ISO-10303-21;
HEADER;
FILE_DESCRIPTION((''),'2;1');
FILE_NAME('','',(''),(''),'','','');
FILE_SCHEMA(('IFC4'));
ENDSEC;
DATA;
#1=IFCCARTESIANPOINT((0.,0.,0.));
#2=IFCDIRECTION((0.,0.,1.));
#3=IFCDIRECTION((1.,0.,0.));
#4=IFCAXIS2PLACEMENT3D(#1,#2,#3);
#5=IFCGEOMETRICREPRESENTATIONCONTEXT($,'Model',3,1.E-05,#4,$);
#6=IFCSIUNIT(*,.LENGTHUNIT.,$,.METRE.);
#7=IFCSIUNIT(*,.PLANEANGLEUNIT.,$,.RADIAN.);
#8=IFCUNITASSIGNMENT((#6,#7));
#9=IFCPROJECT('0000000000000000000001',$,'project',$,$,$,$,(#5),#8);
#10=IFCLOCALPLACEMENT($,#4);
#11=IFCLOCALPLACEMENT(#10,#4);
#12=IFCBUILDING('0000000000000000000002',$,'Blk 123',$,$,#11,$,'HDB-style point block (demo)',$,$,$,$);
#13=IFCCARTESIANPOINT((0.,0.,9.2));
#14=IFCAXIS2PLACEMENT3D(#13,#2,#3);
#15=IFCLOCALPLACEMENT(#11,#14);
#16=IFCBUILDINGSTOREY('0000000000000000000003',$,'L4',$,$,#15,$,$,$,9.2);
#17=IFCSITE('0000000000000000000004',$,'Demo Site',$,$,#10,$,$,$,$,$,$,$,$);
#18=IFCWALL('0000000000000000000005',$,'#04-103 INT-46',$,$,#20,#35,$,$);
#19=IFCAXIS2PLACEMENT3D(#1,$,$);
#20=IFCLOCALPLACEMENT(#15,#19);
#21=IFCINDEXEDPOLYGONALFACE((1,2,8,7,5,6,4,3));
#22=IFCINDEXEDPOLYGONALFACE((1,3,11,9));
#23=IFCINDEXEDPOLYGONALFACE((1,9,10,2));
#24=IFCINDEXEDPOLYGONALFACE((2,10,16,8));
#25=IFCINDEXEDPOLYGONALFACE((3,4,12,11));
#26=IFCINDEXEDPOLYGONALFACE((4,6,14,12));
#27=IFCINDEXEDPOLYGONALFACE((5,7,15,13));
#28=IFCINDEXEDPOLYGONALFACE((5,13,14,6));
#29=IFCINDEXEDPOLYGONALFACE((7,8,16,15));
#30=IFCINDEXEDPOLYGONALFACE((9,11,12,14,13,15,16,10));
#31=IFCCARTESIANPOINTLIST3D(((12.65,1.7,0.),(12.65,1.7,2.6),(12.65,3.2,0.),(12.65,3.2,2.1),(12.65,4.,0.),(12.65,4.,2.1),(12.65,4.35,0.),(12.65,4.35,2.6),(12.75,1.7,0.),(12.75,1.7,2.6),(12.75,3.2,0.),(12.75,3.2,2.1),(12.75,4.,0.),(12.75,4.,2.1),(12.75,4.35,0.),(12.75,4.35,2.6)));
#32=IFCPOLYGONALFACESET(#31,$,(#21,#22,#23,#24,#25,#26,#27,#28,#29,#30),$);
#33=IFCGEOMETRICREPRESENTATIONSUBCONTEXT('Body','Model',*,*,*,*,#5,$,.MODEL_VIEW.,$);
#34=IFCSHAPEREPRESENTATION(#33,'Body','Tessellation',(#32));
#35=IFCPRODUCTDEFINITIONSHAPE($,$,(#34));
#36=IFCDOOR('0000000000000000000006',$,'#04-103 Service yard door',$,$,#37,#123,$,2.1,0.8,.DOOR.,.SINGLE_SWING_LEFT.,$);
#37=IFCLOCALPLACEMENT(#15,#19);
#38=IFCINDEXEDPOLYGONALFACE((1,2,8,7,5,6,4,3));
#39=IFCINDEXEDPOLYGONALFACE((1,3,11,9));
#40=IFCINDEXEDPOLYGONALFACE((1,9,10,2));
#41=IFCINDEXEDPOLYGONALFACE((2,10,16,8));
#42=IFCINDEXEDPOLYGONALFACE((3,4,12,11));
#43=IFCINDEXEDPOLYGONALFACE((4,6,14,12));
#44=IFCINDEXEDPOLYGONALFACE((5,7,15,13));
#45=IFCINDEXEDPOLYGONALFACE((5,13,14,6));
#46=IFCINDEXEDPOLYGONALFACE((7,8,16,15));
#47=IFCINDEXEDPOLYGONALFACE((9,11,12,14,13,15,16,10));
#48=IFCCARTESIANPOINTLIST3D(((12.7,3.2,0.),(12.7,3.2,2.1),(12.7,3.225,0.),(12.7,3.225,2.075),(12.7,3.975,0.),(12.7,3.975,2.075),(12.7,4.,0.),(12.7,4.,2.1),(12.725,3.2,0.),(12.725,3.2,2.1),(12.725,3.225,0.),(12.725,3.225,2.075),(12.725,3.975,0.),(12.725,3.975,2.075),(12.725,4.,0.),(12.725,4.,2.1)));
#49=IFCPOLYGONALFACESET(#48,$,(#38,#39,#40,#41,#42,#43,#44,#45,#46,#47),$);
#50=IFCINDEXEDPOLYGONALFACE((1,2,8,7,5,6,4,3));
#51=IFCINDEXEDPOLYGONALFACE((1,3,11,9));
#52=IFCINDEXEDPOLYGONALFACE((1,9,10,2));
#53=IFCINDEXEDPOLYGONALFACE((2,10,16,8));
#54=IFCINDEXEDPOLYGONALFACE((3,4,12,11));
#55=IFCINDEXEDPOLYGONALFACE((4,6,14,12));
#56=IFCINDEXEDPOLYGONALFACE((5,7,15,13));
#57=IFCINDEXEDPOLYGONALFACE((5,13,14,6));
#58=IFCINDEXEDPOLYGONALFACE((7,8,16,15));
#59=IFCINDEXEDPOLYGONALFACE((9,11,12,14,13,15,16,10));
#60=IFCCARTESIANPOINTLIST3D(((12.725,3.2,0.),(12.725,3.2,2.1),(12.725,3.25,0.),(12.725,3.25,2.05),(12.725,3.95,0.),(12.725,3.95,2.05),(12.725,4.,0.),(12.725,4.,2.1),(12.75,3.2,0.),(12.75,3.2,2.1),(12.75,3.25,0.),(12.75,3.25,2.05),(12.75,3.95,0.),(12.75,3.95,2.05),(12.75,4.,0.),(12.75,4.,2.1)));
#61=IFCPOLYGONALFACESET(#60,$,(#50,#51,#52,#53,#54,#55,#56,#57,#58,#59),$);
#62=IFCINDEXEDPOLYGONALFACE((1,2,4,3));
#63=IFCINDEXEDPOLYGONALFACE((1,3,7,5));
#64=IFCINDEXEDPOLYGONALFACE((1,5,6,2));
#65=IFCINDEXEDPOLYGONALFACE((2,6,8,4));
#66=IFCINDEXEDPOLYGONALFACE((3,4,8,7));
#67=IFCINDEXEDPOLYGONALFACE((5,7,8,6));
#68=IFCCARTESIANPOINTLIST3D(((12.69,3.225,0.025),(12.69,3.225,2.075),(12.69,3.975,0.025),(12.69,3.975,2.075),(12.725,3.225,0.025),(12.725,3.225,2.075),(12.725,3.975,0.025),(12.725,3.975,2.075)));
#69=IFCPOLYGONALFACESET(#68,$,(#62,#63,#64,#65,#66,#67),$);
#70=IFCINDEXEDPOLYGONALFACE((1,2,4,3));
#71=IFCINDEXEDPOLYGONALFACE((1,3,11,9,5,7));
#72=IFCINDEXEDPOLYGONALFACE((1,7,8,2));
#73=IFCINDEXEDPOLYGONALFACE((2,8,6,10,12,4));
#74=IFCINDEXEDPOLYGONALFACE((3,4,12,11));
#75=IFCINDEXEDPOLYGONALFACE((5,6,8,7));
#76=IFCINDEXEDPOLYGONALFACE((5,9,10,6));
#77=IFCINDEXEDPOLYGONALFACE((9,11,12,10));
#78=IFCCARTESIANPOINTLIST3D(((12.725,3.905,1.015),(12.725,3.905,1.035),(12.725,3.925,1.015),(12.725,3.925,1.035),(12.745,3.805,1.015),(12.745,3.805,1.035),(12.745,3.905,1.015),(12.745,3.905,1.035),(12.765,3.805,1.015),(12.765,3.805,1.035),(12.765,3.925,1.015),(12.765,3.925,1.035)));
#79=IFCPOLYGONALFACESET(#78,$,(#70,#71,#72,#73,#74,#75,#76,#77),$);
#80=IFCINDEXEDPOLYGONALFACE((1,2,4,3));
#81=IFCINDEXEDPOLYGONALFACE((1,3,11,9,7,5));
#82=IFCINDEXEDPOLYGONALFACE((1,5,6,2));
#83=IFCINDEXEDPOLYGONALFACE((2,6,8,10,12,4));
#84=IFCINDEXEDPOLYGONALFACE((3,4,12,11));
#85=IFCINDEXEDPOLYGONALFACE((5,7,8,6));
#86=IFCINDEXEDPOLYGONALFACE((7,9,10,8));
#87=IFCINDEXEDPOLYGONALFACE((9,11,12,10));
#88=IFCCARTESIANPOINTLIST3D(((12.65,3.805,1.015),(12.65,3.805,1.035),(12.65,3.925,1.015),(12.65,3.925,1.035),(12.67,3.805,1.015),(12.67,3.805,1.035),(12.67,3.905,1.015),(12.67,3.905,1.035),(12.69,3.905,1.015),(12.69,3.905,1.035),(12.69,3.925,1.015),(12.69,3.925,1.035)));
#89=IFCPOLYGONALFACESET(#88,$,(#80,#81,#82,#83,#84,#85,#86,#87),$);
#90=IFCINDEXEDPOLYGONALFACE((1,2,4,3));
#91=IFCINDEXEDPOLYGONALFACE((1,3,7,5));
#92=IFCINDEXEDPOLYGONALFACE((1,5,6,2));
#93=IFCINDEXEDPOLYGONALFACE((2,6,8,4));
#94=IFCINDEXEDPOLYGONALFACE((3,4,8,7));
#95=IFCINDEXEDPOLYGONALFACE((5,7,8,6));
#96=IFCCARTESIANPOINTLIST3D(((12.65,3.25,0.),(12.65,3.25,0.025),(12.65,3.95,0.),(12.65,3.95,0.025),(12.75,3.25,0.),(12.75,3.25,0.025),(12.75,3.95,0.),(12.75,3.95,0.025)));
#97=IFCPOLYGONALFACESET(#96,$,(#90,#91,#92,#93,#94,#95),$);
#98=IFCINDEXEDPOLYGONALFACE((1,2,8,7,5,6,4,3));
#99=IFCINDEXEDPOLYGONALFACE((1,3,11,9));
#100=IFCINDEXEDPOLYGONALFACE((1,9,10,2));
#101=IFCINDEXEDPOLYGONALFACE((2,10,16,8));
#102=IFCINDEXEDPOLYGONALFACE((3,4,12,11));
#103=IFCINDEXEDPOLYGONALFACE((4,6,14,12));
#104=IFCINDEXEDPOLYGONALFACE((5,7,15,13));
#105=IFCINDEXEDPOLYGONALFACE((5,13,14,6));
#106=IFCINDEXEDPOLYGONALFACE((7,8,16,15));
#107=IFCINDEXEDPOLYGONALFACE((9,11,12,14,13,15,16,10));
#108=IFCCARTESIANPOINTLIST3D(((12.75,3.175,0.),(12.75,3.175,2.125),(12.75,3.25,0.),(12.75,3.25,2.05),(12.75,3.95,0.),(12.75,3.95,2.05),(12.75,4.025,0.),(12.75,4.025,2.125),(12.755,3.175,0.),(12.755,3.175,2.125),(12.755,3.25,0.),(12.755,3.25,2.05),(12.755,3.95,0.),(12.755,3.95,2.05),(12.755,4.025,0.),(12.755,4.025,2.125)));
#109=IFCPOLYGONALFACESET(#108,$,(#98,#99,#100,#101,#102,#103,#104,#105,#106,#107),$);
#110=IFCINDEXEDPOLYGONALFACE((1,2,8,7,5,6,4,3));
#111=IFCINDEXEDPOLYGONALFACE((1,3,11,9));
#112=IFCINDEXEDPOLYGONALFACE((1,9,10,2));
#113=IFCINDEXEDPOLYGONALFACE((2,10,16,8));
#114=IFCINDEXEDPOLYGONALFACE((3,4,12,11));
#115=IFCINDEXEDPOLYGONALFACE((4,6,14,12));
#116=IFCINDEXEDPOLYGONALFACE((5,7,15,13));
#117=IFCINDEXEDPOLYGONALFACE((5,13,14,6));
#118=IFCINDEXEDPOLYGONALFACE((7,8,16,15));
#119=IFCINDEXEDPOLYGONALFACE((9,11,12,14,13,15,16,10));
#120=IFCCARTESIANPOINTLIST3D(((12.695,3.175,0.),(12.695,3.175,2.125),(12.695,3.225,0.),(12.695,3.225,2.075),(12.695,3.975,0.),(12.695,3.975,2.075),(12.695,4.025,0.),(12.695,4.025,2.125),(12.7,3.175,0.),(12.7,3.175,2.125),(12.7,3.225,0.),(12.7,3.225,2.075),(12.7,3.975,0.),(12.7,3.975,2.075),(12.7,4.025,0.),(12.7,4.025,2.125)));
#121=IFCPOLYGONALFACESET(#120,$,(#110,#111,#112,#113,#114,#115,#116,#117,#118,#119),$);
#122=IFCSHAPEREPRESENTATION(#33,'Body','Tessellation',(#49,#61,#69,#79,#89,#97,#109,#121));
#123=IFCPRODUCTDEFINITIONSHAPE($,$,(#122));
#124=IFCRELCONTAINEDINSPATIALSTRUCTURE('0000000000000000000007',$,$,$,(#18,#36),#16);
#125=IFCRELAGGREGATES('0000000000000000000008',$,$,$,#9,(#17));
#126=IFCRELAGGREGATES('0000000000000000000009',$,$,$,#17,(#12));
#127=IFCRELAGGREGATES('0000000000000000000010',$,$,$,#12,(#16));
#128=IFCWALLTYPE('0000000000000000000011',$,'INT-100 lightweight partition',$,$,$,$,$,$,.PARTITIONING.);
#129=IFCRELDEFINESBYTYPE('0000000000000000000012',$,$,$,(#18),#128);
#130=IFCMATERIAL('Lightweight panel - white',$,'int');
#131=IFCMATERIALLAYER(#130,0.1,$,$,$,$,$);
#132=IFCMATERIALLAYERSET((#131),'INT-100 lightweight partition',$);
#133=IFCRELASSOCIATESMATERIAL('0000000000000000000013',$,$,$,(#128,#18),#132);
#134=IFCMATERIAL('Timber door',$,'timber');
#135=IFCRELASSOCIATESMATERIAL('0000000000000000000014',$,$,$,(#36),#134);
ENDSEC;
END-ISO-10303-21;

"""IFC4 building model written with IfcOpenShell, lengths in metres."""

from ifc_helpers import new_model, si_unit, frame, origin_with_axes, place, context, subcontext, project, spatial, line, indexed_curve, outline, extrude, material, layer, layer_set, layer_usage, type_object, element, fill, save


model = new_model("IFC4")

# Units and contexts
model_context = context("Model", 3, precision=1e-05, world=origin_with_axes())
body_context = subcontext(model_context, "Body", "Model", "MODEL_VIEW")
ifc_project = project(units=[si_unit("LENGTHUNIT", "METRE"), si_unit("PLANEANGLEUNIT", "RADIAN")], contexts=[model_context])

# Site, building, storey
site_placement = place(None, origin_with_axes())
site = spatial("IfcSite", under=ifc_project, at=site_placement, Name="Demo Site")
building_placement = place(site_placement, origin_with_axes())
building = spatial("IfcBuilding", under=site, at=building_placement, Name="Blk 123", LongName="HDB-style point block (demo)")
storey_placement = place(building_placement, frame((0.0, 0.0, 9.2), z_axis=(0.0, 0.0, 1.0), x_axis=(1.0, 0.0, 0.0)))
storey = spatial("IfcBuildingStorey", under=building, at=storey_placement, Name="L4", Elevation=9.2)

# Shared definitions
ifc_material_1 = material(Name="Timber door", Category="timber")

# Wall, opening, door
ifc_material_2 = material(Name="Lightweight panel - white", Category="int")
ifc_layer_1 = layer(ifc_material_2, 0.1)
ifc_layer_set_1 = layer_set([ifc_layer_1], Name="INT-100 lightweight partition")
ifc_layer_usage_1 = layer_usage(ifc_layer_set_1, "AXIS2", "POSITIVE", -0.05)
wall_type_1 = type_object("IfcWallType", Name="INT-100 lightweight partition", PredefinedType="PARTITIONING", material=ifc_layer_set_1)
wall_1_placement = place(storey_placement, frame((12.7, 1.7, 0.0), z_axis=(0.0, 0.0, 1.0), x_axis=(0.0, 1.0, 0.0)))
wall_1 = element("IfcWall", 1, at=wall_1_placement, inside=storey, type_object=wall_type_1, material=ifc_layer_usage_1, Name="#04-103 INT-46", context=body_context, shape_type="SweptSolid", body=[
    extrude(outline(indexed_curve([(0.0, 0.0), (0.0, 0.1), (2.65, 0.1), (2.65, 0.0), (0.0, 0.0)], self_intersect=False)), frame((0.0, -0.05, 0.0), z_axis=(0.0, 0.0, 1.0), x_axis=(1.0, 0.0, 0.0)), (0.0, 0.0, 1.0), 2.6),
])
opening_1_placement = place(wall_1_placement, frame((1.5, -0.15, 0.0), z_axis=(0.0, 0.0, 1.0), x_axis=(1.0, 0.0, 0.0)))
opening_1 = element("IfcOpeningElement", 2, at=opening_1_placement, cuts=wall_1, context=body_context, shape_type="SweptSolid", body=[
    extrude(outline(indexed_curve([(0.0, 0.0), (0.0, 0.3), (0.8, 0.3), (0.8, 0.0), (0.0, 0.0)], self_intersect=False)), origin_with_axes(), (0.0, 0.0, 1.0), 2.1),
])
door_1_placement = place(opening_1_placement, frame((0.0, 0.1, 0.0), z_axis=(0.0, 0.0, 1.0), x_axis=(1.0, 0.0, 0.0)))
door_1 = element("IfcDoor", 3, at=door_1_placement, inside=storey, material=ifc_material_1, Name="#04-103 Service yard door", OperationType="SINGLE_SWING_LEFT", OverallHeight=2.1, OverallWidth=0.8, PredefinedType="DOOR", context=body_context, shape_type="SweptSolid", body=[
    extrude(outline(indexed_curve([(0.0, 0.0), (0.0, 2.1), (0.8, 2.1), (0.8, 0.0), (0.775, 0.0), (0.775, 2.075), (0.025, 2.075), (0.025, 0.0)], segments=[line(1, 2, 3, 4, 5, 6, 7, 8, 1)])), frame((0.0, 0.025, 0.0), z_axis=(0.0, -1.0, 0.0), x_axis=(1.0, 0.0, 0.0)), (0.0, 0.0, -1.0), 0.025),
    extrude(outline(indexed_curve([(0.0, 0.0), (0.0, 2.1), (0.8, 2.1), (0.8, 0.0), (0.75, 0.0), (0.75, 2.05), (0.05, 2.05), (0.05, 0.0)], segments=[line(1, 2, 3, 4, 5, 6, 7, 8, 1)])), frame((0.0, 0.0, 0.0), z_axis=(0.0, -1.0, 0.0), x_axis=(1.0, 0.0, 0.0)), (0.0, 0.0, -1.0), 0.025),
    extrude(outline(indexed_curve([(0.0, 0.0), (0.75, 0.0), (0.75, 0.035), (0.0, 0.035)], segments=[line(1, 2, 3, 4, 1)])), frame((0.025, 0.025, 0.025), z_axis=(0.0, 0.0, 1.0), x_axis=(1.0, 0.0, 0.0)), (0.0, 0.0, 1.0), 2.05),
    extrude(outline(indexed_curve([(0.0, 0.0), (0.0, -0.04), (-0.12, -0.04), (-0.12, -0.02), (-0.02, -0.02), (-0.02, 0.0)], segments=[line(1, 2, 3, 4, 5, 6, 1)])), frame((0.725, 0.025, 1.015), z_axis=(0.0, 0.0, 1.0), x_axis=(1.0, 0.0, 0.0)), (0.0, 0.0, 1.0), 0.02),
    extrude(outline(indexed_curve([(0.0, 0.0), (0.0, 0.04), (-0.12, 0.04), (-0.12, 0.02), (-0.02, 0.02), (-0.02, 0.0)], segments=[line(1, 2, 3, 4, 5, 6, 1)])), frame((0.725, 0.06, 1.015), z_axis=(0.0, 0.0, 1.0), x_axis=(1.0, 0.0, 0.0)), (0.0, 0.0, 1.0), 0.02),
    extrude(outline(indexed_curve([(0.0, 0.0), (0.7, 0.0), (0.7, 0.1), (0.0, 0.1)], segments=[line(1, 2, 3, 4, 1)])), frame((0.05, 0.0, 0.0), z_axis=(0.0, 0.0, 1.0), x_axis=(1.0, 0.0, 0.0)), (0.0, 0.0, 1.0), 0.025),
    extrude(outline(indexed_curve([(0.0, 0.0), (0.0, 2.125), (0.85, 2.125), (0.85, 0.0), (0.775, 0.0), (0.775, 2.05), (0.075, 2.05), (0.075, 0.0)], segments=[line(1, 2, 3, 4, 5, 6, 7, 8, 1)])), frame((-0.025, -0.005, 0.0), z_axis=(0.0, -1.0, 0.0), x_axis=(1.0, 0.0, 0.0)), (0.0, 0.0, -1.0), 0.005),
    extrude(outline(indexed_curve([(0.0, 0.0), (0.0, 2.125), (0.85, 2.125), (0.85, 0.0), (0.8, 0.0), (0.8, 2.075), (0.05, 2.075), (0.05, 0.0)], segments=[line(1, 2, 3, 4, 5, 6, 7, 8, 1)])), frame((-0.025, 0.05, 0.0), z_axis=(0.0, -1.0, 0.0), x_axis=(1.0, 0.0, 0.0)), (0.0, 0.0, -1.0), 0.005),
])
fill(opening_1, door_1)

save(model, "model.ifc")
